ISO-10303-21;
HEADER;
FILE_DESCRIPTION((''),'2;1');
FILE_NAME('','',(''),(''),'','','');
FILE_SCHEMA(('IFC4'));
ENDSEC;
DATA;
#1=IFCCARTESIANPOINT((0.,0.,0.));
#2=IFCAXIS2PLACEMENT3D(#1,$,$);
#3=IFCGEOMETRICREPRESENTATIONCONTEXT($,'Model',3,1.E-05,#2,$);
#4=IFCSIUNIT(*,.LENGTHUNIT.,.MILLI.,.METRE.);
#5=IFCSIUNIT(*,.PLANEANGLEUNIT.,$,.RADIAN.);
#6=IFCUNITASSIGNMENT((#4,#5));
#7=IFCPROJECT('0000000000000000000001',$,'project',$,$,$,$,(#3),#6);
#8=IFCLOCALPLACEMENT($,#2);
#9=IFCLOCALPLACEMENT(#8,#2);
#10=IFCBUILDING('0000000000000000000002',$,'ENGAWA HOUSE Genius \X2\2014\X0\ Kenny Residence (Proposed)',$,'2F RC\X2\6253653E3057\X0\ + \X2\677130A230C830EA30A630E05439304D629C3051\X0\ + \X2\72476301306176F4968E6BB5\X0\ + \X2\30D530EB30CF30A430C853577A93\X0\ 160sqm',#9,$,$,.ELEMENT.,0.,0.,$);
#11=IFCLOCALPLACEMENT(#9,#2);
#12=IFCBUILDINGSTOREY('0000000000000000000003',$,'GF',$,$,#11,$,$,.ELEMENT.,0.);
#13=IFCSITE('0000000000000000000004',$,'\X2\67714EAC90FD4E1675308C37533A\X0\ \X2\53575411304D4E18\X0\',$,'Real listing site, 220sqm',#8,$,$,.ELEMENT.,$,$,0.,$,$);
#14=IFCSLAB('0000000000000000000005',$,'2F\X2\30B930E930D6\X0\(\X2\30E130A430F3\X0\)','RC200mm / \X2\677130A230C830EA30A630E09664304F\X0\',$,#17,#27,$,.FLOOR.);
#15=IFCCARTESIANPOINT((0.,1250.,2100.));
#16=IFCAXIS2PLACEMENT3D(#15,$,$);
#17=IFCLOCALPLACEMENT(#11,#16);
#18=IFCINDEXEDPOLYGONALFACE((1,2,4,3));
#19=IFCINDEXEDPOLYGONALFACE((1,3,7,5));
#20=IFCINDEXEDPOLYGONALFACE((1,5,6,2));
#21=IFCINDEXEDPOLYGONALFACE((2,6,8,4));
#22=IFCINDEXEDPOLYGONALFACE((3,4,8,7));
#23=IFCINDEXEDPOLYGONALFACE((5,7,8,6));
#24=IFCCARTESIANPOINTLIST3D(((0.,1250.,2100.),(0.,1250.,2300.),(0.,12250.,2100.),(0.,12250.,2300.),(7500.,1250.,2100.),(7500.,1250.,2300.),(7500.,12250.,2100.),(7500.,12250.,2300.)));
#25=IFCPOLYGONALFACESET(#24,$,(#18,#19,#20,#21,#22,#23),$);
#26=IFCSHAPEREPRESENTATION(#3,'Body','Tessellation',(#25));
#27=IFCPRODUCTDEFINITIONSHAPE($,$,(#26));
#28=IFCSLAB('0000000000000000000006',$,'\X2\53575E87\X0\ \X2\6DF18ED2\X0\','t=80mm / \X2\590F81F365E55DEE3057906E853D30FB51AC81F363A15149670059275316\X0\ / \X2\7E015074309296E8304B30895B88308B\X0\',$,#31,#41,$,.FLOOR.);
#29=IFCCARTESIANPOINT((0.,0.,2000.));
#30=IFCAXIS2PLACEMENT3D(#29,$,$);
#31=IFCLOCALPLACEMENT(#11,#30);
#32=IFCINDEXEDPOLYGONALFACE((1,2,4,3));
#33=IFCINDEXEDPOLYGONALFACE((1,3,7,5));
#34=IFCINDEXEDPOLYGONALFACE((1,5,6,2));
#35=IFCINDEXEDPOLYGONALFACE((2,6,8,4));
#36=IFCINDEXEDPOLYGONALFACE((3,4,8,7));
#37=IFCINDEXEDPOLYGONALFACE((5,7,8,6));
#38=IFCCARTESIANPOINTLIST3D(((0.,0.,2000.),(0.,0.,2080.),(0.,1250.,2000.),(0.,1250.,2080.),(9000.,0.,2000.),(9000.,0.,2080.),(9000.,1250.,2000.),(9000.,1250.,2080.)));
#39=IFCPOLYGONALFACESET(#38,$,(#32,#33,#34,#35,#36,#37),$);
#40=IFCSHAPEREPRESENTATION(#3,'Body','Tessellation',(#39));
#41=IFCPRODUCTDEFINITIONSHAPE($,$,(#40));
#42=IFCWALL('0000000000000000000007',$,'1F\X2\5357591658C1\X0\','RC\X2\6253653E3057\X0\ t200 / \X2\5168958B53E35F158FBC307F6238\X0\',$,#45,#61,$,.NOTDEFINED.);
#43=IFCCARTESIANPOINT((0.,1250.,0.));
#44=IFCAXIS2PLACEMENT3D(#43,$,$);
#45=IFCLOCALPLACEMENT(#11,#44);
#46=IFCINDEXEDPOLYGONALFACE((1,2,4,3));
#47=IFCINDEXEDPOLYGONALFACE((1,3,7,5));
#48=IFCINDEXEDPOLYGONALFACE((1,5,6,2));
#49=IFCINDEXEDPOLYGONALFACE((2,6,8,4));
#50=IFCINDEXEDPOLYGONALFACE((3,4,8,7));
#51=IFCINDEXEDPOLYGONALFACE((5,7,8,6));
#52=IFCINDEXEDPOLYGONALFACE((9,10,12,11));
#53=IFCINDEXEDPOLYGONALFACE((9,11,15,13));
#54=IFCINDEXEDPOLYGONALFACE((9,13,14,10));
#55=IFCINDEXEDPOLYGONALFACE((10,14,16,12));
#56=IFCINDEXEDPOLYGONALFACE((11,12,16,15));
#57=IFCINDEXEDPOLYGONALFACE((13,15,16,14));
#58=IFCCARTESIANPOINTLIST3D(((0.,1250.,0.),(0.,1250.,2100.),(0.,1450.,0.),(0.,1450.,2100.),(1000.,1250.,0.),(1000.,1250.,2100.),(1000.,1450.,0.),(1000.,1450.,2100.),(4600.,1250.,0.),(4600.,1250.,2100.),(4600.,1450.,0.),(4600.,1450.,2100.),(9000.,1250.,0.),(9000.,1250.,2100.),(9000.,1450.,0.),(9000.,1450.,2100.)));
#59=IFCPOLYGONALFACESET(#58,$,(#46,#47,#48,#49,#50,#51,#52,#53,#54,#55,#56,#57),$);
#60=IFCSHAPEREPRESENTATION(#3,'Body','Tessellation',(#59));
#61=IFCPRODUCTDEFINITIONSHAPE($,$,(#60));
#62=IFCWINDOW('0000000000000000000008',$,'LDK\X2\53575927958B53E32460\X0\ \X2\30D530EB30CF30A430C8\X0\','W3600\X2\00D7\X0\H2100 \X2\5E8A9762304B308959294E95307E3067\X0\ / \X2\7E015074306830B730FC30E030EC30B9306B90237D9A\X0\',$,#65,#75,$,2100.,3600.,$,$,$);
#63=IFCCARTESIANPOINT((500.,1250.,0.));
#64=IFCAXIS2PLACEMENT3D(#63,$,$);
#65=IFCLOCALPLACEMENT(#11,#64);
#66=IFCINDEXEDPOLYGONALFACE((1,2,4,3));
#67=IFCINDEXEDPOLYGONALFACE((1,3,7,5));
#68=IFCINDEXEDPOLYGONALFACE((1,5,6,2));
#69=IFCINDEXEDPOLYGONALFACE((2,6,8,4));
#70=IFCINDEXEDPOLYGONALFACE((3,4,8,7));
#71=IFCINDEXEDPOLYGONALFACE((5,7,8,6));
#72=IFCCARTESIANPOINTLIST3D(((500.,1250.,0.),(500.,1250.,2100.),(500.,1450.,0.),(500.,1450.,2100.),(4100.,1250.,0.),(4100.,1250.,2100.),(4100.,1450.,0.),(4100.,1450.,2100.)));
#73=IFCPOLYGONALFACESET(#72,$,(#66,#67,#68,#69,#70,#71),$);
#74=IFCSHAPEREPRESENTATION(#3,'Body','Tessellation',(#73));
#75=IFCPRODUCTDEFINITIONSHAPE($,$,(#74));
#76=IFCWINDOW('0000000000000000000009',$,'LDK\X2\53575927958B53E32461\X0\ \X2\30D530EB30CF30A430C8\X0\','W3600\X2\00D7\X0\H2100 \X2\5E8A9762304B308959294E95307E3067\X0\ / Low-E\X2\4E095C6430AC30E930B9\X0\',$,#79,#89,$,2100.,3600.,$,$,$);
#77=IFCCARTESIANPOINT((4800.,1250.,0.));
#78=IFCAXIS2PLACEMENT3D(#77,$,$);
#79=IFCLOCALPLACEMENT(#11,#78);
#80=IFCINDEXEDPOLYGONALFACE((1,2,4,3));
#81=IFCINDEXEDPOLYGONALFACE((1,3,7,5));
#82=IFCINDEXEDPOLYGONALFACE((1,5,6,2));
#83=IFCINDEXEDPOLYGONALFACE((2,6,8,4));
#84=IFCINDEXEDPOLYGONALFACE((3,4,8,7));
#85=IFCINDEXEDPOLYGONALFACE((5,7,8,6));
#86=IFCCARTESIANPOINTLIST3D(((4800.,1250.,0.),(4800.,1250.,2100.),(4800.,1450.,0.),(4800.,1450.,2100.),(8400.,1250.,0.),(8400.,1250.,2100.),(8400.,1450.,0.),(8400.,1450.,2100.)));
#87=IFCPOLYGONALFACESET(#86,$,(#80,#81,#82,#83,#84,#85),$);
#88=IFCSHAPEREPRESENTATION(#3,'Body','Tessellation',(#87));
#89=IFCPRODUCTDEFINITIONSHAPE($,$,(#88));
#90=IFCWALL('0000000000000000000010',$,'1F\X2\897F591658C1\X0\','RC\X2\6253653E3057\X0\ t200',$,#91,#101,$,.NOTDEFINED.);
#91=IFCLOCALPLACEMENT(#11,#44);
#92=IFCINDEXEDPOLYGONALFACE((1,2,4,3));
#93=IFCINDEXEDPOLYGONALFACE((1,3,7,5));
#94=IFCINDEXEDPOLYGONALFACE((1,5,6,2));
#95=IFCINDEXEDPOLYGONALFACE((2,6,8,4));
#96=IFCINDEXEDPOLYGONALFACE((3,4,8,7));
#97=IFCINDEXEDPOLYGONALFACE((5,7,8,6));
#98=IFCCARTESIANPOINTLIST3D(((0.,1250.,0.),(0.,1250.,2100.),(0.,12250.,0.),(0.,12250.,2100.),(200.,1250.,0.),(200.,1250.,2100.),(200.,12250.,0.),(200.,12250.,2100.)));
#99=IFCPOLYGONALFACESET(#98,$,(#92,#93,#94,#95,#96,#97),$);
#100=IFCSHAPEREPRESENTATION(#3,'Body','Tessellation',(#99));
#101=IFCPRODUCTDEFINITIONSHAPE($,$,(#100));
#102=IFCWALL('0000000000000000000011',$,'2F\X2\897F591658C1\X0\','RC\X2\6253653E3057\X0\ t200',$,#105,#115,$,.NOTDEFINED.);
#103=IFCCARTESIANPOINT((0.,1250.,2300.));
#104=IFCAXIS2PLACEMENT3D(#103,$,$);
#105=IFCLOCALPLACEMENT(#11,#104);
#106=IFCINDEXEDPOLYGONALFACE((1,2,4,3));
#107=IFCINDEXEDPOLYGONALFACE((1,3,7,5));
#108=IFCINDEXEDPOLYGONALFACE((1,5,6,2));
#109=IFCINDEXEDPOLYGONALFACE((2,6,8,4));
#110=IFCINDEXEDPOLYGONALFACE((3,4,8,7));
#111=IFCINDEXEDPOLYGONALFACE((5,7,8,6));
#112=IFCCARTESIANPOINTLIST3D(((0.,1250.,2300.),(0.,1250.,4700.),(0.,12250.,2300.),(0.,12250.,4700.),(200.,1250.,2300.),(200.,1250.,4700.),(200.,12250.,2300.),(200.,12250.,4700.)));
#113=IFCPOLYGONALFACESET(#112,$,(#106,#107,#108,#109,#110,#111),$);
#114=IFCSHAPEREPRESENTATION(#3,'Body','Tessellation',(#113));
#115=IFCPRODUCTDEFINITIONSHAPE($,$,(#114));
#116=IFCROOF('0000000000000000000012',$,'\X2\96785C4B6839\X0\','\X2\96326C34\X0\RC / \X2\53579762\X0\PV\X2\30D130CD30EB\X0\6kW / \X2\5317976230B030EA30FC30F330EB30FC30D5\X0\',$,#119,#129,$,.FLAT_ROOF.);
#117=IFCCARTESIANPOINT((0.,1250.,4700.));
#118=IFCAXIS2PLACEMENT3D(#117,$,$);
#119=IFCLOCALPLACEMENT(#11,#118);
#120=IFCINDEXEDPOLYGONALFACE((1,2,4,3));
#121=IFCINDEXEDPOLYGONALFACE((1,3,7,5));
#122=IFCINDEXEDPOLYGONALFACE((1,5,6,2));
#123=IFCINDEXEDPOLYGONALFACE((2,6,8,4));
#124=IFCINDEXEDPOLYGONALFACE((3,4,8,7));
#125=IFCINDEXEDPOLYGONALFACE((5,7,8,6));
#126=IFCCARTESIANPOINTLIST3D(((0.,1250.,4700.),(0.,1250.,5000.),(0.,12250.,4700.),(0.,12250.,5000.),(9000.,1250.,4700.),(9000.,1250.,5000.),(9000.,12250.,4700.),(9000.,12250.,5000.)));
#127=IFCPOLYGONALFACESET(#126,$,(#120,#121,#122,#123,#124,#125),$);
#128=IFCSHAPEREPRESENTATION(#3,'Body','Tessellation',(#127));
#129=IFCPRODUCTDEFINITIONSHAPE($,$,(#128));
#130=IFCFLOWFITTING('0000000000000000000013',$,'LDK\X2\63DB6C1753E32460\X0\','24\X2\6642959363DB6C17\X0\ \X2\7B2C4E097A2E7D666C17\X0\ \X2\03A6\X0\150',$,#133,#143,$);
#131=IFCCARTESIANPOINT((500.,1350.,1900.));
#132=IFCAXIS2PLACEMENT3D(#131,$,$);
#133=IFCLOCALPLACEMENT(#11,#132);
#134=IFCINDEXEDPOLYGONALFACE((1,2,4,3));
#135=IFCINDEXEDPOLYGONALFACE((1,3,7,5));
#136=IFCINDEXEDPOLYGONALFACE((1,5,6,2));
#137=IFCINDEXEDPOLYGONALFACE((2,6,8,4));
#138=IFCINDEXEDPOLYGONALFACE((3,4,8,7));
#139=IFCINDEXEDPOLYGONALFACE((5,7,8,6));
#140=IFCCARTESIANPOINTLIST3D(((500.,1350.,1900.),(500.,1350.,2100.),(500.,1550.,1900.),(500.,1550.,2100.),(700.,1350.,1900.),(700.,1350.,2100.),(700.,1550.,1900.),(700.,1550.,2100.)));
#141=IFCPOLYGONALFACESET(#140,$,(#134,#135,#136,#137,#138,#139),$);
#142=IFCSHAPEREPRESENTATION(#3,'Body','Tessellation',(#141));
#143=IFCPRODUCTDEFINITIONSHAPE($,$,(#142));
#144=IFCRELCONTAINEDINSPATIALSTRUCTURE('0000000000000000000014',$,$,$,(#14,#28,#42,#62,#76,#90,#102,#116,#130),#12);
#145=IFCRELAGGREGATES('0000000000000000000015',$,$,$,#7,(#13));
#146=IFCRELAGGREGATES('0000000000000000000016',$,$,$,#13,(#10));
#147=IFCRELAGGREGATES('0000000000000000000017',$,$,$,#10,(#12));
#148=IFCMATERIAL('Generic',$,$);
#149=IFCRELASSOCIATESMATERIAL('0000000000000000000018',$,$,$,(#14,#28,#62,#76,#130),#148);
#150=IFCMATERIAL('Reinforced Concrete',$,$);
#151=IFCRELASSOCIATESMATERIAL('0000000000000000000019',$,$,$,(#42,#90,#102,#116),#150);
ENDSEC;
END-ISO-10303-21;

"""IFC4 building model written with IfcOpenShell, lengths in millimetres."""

from ifc_helpers import new_model, si_unit, frame, frame_2d, origin, place, context, project, spatial, rectangle, extrude, material, element, fill, save


model = new_model("IFC4")

# Units and contexts
model_context = context("Model", 3, precision=1e-05, world=origin())
ifc_project = project(units=[si_unit("LENGTHUNIT", "METRE", prefix="MILLI"), si_unit("PLANEANGLEUNIT", "RADIAN")], contexts=[model_context])

# Site, building, storey
site_placement = place(None, origin())
site = spatial("IfcSite", under=ifc_project, at=site_placement, Name="東京都世田谷区 南向き丘", ObjectType="Real listing site, 220sqm", CompositionType="ELEMENT", RefElevation=0.0)
building_placement = place(site_placement, origin())
building = spatial("IfcBuilding", under=site, at=building_placement, Name="ENGAWA HOUSE Genius — Kenny Residence (Proposed)", ObjectType="2F RC打放し + 東アトリウム吹き抜け + 片持ち直階段 + フルハイト南窓 160sqm", CompositionType="ELEMENT", ElevationOfRefHeight=0.0, ElevationOfTerrain=0.0)
storey_placement = place(building_placement, origin())
storey = spatial("IfcBuildingStorey", under=building, at=storey_placement, Name="GF", CompositionType="ELEMENT", Elevation=0.0)

# Slabs
ifc_material_1 = material(Name="Reinforced Concrete")
ifc_material_2 = material(Name="Generic")
slab_1_placement = place(storey_placement, frame((0.0, 1250.0, 2100.0)))
element("IfcSlab", 1, at=slab_1_placement, inside=storey, material=ifc_material_2, Name="2Fスラブ(メイン)", Description="RC200mm / 東アトリウム除く", PredefinedType="FLOOR", context=model_context, shape_type="SweptSolid", body=[
    extrude(rectangle(XDim=7500.0, YDim=11000.0, at=frame_2d((3750.0, 5500.0))), frame((0.0, 1250.0, 2100.0)), (0.0, 0.0, 1.0), 200.0),
])
slab_2_placement = place(storey_placement, frame((0.0, 0.0, 2000.0)))
element("IfcSlab", 2, at=slab_2_placement, inside=storey, material=ifc_material_2, Name="南庇 深軒", Description="t=80mm / 夏至日差し遮蔽・冬至採光最大化 / 縁側を雨から守る", PredefinedType="FLOOR", context=model_context, shape_type="SweptSolid", body=[
    extrude(rectangle(XDim=9000.0, YDim=1250.0, at=frame_2d((4500.0, 625.0))), frame((0.0, 0.0, 2000.0)), (0.0, 0.0, 1.0), 80.0),
])

# Wall, openings, windows
wall_1_placement = place(storey_placement, frame((0.0, 1250.0, 0.0)))
wall_1 = element("IfcWall", 3, at=wall_1_placement, inside=storey, material=ifc_material_1, Name="1F南外壁", Description="RC打放し t200 / 全開口引込み戸", PredefinedType="NOTDEFINED", context=model_context, shape_type="SweptSolid", body=[
    extrude(rectangle(XDim=9000.0, YDim=200.0, at=frame_2d((4500.0, 100.0))), frame((0.0, 1250.0, 0.0)), (0.0, 0.0, 1.0), 2100.0),
])
opening_1_placement = place(storey_placement, frame((500.0, 1250.0, 0.0)))
opening_1 = element("IfcOpeningElement", 4, at=opening_1_placement, cuts=wall_1, PredefinedType="NOTDEFINED", context=model_context, shape_type="SweptSolid", body=[
    extrude(rectangle(XDim=3600.0, YDim=200.0, at=frame_2d((1800.0, 100.0))), frame((500.0, 1250.0, 0.0)), (0.0, 0.0, 1.0), 2100.0),
])
opening_2_placement = place(storey_placement, frame((4800.0, 1250.0, 0.0)))
opening_2 = element("IfcOpeningElement", 5, at=opening_2_placement, cuts=wall_1, PredefinedType="NOTDEFINED", context=model_context, shape_type="SweptSolid", body=[
    extrude(rectangle(XDim=3600.0, YDim=200.0, at=frame_2d((1800.0, 100.0))), frame((4800.0, 1250.0, 0.0)), (0.0, 0.0, 1.0), 2100.0),
])
window_1_placement = place(storey_placement, frame((500.0, 1250.0, 0.0)))
window_1 = element("IfcWindow", 6, at=window_1_placement, inside=storey, material=ifc_material_2, Name="LDK南大開口① フルハイト", Description="W3600×H2100 床面から天井まで / 縁側とシームレスに連続", OverallHeight=2100.0, OverallWidth=3600.0, context=model_context, shape_type="SweptSolid", body=[
    extrude(rectangle(XDim=3600.0, YDim=200.0, at=frame_2d((1800.0, 100.0))), frame((500.0, 1250.0, 0.0)), (0.0, 0.0, 1.0), 2100.0),
])
fill(opening_1, window_1)
window_2_placement = place(storey_placement, frame((4800.0, 1250.0, 0.0)))
window_2 = element("IfcWindow", 7, at=window_2_placement, inside=storey, material=ifc_material_2, Name="LDK南大開口② フルハイト", Description="W3600×H2100 床面から天井まで / Low-E三層ガラス", OverallHeight=2100.0, OverallWidth=3600.0, context=model_context, shape_type="SweptSolid", body=[
    extrude(rectangle(XDim=3600.0, YDim=200.0, at=frame_2d((1800.0, 100.0))), frame((4800.0, 1250.0, 0.0)), (0.0, 0.0, 1.0), 2100.0),
])
fill(opening_2, window_2)

# Wall
wall_2_placement = place(storey_placement, frame((0.0, 1250.0, 0.0)))
element("IfcWall", 8, at=wall_2_placement, inside=storey, material=ifc_material_1, Name="1F西外壁", Description="RC打放し t200", PredefinedType="NOTDEFINED", context=model_context, shape_type="SweptSolid", body=[
    extrude(rectangle(XDim=200.0, YDim=11000.0, at=frame_2d((100.0, 5500.0))), frame((0.0, 1250.0, 0.0)), (0.0, 0.0, 1.0), 2100.0),
])

# Wall
wall_3_placement = place(storey_placement, frame((0.0, 1250.0, 2300.0)))
element("IfcWall", 9, at=wall_3_placement, inside=storey, material=ifc_material_1, Name="2F西外壁", Description="RC打放し t200", PredefinedType="NOTDEFINED", context=model_context, shape_type="SweptSolid", body=[
    extrude(rectangle(XDim=200.0, YDim=11000.0, at=frame_2d((100.0, 5500.0))), frame((0.0, 1250.0, 2300.0)), (0.0, 0.0, 1.0), 2400.0),
])

# Roof
roof_placement = place(storey_placement, frame((0.0, 1250.0, 4700.0)))
element("IfcRoof", 10, at=roof_placement, inside=storey, material=ifc_material_1, Name="陸屋根", Description="防水RC / 南面PVパネル6kW / 北面グリーンルーフ", PredefinedType="FLAT_ROOF", context=model_context, shape_type="SweptSolid", body=[
    extrude(rectangle(XDim=9000.0, YDim=11000.0, at=frame_2d((4500.0, 5500.0))), frame((0.0, 1250.0, 4700.0)), (0.0, 0.0, 1.0), 300.0),
])

# Flow fitting
flow_fitting_placement = place(storey_placement, frame((500.0, 1350.0, 1900.0)))
element("IfcFlowFitting", 11, at=flow_fitting_placement, inside=storey, material=ifc_material_2, Name="LDK換気口①", Description="24時間換気 第三種給気 Φ150", context=model_context, shape_type="SweptSolid", body=[
    extrude(rectangle(XDim=200.0, YDim=200.0, at=frame_2d((100.0, 100.0))), frame((500.0, 1350.0, 1900.0)), (0.0, 0.0, 1.0), 200.0),
])

save(model, "model.ifc")
